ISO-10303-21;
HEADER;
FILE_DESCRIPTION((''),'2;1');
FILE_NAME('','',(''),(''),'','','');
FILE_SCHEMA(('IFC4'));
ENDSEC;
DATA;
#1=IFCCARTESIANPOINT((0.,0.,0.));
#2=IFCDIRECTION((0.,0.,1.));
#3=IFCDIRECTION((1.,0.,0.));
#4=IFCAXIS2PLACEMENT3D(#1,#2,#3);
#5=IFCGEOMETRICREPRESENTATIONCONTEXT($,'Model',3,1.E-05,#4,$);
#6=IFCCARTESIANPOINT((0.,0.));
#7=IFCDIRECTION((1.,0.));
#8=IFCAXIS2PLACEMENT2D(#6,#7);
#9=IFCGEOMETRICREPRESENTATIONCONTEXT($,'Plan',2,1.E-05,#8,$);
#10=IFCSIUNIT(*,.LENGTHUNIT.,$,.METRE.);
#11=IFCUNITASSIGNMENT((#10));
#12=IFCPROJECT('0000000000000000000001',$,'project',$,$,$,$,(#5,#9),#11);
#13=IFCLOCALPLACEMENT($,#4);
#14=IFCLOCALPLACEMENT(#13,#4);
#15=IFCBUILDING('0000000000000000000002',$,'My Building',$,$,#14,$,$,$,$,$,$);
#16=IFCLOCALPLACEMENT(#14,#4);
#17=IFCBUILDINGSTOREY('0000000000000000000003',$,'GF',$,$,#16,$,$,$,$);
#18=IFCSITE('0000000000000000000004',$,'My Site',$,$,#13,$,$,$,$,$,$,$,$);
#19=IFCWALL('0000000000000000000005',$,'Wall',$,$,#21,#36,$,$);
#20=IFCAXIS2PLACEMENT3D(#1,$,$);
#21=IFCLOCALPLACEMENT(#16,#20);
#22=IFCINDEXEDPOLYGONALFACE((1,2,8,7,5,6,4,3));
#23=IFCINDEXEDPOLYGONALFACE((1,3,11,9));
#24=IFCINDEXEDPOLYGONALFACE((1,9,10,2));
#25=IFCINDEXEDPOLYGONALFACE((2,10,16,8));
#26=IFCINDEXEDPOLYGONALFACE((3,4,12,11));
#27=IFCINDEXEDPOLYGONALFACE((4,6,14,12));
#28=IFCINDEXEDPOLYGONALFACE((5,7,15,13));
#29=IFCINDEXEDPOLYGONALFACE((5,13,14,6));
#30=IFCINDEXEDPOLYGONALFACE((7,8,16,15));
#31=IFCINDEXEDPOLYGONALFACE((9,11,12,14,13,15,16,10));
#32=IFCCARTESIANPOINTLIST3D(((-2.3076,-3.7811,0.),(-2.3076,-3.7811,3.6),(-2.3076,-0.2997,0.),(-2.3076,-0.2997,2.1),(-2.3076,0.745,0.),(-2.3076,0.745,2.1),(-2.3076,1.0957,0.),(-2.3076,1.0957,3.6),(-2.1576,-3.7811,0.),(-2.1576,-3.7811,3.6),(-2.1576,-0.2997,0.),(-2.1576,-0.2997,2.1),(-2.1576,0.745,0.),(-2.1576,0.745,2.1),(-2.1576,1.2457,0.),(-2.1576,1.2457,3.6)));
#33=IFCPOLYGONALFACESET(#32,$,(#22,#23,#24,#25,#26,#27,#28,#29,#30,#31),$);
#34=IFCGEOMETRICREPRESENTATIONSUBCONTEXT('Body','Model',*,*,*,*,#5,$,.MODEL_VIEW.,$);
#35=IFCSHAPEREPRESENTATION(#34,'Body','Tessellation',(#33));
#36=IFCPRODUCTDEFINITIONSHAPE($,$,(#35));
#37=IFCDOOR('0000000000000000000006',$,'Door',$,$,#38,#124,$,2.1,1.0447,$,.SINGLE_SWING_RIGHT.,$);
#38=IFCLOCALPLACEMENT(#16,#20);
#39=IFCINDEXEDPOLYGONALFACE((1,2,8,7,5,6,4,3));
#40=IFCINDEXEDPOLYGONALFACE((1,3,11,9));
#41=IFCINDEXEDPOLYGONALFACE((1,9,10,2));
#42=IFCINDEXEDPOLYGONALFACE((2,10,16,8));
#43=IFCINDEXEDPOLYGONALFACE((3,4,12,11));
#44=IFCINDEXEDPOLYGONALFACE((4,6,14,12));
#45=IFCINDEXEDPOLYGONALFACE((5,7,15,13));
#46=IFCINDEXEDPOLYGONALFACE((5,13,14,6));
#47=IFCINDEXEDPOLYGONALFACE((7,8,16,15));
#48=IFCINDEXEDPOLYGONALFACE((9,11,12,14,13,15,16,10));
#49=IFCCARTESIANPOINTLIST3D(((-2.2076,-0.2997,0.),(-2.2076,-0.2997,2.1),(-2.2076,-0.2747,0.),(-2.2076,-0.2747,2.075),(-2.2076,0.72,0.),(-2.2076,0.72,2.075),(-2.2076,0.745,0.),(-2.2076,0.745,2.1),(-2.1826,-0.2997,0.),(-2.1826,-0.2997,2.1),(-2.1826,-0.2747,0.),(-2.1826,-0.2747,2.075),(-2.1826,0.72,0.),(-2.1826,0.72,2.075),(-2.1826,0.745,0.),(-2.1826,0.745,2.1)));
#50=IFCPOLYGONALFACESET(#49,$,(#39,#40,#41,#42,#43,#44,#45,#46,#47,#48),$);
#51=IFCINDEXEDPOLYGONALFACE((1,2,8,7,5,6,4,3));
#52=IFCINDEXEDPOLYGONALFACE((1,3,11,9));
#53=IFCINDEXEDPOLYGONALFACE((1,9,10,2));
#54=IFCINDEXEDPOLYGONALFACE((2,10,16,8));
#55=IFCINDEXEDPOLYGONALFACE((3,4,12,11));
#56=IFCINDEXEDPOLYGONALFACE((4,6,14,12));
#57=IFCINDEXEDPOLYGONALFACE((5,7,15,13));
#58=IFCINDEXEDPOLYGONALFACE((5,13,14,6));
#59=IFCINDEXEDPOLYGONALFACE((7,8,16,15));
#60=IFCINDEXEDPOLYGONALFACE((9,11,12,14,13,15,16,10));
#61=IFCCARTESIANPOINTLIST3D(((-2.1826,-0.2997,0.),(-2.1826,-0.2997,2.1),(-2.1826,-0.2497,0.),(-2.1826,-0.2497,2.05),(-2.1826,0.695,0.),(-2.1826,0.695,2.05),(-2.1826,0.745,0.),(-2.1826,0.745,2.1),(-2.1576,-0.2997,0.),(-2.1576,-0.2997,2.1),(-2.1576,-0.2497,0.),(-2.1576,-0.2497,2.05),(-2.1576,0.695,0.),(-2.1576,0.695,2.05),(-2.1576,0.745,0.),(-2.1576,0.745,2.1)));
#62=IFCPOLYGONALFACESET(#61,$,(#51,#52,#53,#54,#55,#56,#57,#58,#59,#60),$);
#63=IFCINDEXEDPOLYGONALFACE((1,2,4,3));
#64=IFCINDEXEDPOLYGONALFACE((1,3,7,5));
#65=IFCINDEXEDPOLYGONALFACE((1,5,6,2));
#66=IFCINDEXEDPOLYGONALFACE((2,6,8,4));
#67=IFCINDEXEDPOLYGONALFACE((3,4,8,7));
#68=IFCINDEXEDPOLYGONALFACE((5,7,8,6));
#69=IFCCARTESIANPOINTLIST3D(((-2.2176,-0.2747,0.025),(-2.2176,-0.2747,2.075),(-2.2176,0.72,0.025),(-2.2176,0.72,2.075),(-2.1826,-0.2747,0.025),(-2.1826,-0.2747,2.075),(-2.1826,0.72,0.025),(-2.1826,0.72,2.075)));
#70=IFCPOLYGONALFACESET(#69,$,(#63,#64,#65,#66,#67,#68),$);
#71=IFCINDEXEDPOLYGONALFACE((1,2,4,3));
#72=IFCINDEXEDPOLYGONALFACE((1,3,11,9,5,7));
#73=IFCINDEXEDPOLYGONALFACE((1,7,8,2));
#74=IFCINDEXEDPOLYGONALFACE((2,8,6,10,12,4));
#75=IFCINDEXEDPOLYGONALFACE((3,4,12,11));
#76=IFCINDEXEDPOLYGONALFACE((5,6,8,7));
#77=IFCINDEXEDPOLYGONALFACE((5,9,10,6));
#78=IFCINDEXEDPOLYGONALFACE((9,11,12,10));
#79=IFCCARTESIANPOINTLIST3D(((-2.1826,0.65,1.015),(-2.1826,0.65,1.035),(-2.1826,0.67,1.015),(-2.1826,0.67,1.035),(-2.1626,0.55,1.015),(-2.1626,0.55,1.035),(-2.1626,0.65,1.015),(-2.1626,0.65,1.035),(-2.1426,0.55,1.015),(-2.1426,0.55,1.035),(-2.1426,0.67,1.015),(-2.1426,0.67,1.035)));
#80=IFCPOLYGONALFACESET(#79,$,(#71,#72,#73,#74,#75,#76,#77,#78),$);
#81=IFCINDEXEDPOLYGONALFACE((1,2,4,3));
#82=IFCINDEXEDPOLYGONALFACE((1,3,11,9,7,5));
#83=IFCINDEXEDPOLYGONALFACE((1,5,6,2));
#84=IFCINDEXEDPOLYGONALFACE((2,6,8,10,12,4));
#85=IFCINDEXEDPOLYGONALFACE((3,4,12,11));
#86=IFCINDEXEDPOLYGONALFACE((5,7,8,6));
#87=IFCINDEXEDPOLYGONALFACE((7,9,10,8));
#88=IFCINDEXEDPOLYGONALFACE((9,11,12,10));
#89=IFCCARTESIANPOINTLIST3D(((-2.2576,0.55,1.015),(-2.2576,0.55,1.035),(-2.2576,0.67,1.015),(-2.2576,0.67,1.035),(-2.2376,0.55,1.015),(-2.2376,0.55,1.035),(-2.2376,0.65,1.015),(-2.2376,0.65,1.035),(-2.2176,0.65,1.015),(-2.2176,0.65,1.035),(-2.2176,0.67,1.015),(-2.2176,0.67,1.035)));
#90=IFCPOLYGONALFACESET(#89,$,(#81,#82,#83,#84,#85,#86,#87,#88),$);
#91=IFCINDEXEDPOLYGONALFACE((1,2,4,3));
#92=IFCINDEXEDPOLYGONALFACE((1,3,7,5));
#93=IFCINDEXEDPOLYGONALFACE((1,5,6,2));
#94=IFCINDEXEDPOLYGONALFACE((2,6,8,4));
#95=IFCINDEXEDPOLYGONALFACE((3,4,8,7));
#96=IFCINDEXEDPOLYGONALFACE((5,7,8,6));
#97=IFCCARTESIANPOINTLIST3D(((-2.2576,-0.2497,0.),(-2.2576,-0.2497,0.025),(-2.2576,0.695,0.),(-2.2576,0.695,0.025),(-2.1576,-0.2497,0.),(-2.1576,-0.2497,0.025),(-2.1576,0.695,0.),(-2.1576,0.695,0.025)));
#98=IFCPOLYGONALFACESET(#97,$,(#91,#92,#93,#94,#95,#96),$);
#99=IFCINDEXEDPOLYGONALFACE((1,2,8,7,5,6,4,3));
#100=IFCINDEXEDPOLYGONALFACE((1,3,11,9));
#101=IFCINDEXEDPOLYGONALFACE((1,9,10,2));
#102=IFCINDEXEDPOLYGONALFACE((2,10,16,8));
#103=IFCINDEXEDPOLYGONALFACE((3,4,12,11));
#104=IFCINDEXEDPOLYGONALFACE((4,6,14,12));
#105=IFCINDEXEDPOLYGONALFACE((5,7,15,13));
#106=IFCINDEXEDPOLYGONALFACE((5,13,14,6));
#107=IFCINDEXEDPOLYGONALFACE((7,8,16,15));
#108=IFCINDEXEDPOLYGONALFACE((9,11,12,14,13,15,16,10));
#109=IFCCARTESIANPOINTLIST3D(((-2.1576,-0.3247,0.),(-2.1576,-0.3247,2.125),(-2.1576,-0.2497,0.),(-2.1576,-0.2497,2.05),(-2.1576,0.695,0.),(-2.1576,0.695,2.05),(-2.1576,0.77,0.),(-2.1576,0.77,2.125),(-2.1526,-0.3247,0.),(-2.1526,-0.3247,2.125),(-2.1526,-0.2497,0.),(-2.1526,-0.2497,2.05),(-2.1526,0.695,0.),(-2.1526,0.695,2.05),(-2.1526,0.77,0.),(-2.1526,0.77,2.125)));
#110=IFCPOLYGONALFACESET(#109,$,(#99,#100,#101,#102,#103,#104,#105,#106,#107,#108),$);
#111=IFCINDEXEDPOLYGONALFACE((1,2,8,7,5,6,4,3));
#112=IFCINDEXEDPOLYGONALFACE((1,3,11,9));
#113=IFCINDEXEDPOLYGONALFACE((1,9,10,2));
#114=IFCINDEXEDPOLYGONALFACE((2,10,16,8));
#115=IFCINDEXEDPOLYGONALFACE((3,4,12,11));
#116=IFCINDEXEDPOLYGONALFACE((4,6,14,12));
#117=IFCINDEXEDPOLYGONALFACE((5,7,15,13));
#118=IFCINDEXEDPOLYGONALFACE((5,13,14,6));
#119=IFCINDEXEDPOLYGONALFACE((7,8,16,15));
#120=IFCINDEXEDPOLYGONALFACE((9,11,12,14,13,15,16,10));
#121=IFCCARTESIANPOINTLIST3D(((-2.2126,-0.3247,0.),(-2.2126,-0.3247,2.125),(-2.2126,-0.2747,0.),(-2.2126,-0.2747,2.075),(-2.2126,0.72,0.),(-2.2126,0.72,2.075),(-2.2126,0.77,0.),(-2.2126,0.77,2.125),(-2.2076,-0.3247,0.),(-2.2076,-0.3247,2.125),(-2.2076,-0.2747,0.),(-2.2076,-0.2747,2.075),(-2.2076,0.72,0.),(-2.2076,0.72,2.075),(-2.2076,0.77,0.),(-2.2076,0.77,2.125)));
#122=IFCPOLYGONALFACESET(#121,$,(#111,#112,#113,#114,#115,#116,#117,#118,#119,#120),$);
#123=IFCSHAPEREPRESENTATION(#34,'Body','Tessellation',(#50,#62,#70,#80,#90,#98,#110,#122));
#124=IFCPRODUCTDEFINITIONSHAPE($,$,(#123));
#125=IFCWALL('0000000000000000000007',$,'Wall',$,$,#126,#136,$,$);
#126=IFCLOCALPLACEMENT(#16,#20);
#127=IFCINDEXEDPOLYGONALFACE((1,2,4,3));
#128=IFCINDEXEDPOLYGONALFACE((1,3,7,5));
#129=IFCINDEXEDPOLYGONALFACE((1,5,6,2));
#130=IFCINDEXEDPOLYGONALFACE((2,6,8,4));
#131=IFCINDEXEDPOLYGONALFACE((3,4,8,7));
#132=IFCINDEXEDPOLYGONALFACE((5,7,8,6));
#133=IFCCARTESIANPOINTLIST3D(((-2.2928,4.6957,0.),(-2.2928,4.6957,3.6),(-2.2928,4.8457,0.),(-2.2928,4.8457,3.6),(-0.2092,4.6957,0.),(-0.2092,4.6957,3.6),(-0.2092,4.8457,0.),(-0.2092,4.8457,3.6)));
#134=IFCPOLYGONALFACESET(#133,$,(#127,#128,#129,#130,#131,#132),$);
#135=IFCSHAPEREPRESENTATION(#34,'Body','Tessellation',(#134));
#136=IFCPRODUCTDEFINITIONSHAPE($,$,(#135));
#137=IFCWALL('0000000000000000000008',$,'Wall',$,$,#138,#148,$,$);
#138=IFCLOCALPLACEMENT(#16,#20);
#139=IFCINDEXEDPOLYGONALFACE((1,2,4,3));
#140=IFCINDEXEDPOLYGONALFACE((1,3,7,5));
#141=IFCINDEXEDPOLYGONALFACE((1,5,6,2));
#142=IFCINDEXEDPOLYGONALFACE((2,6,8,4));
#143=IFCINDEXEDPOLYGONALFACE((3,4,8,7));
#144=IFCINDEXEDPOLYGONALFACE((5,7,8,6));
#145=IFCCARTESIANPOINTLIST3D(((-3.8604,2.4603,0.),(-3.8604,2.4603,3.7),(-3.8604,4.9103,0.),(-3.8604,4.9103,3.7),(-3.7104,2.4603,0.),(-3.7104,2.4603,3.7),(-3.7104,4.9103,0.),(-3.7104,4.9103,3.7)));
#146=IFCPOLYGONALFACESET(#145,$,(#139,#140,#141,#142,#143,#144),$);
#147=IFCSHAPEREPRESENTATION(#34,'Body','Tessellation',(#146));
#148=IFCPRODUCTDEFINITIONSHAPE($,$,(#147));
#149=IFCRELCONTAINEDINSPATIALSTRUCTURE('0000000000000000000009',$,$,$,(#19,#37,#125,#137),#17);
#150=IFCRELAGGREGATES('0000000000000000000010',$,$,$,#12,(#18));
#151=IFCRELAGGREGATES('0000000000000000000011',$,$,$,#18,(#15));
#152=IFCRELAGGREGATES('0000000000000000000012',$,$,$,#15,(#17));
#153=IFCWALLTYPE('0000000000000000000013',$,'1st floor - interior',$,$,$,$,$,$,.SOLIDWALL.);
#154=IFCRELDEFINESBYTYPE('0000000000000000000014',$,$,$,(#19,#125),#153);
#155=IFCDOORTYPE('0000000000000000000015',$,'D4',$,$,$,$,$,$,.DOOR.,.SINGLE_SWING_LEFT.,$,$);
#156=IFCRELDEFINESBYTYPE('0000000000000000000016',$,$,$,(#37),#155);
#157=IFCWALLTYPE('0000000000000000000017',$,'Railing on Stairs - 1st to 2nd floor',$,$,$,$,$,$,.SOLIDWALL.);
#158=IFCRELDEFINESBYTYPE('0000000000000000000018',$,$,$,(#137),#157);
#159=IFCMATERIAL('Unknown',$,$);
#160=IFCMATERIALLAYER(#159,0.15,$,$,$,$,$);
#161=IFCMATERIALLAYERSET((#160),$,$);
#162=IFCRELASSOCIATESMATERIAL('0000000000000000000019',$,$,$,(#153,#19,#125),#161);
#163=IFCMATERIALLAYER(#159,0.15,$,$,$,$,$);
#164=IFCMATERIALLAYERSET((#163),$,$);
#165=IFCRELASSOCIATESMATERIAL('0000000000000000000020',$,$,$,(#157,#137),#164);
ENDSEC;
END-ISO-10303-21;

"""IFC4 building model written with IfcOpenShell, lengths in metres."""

from ifc_helpers import new_model, entity, si_unit, frame, origin_with_axes, origin_2d_with_axis, place, context, subcontext, project, spatial, line, indexed_curve, outline, extrude, shape, source, transform, mapped, material, layer, layer_set, layer_usage, type_object, type_shapes, element, fill, save


model = new_model("IFC4")

# Units and contexts
model_context = context("Model", 3, precision=1e-05, world=origin_with_axes())
plan_context = context("Plan", 2, precision=1e-05, world=origin_2d_with_axis())
body_context_1 = subcontext(model_context, "Body", "Model", "MODEL_VIEW")
body_context_2 = subcontext(plan_context, "Body", "Plan", "PLAN_VIEW")
ifc_project = project(units=[si_unit("LENGTHUNIT", "METRE")], contexts=[model_context, plan_context])

# Site, building, storey
site_placement = place(None, origin_with_axes())
site = spatial("IfcSite", under=ifc_project, at=site_placement, Name="My Site")
building_placement = place(site_placement, origin_with_axes())
building = spatial("IfcBuilding", under=site, at=building_placement, Name="My Building")
storey_placement = place(building_placement, origin_with_axes())
storey = spatial("IfcBuildingStorey", under=building, at=storey_placement, Name="GF")

# Shared definitions
ifc_material = material(Name="Unknown")

# Shared definitions
ifc_layer_1 = layer(ifc_material, 0.15)
ifc_layer_set_1 = layer_set([ifc_layer_1])
wall_type_1 = type_object("IfcWallType", Name="1st floor - interior", PredefinedType="SOLIDWALL", material=ifc_layer_set_1)

# Wall, opening, door
ifc_layer_usage_1 = layer_usage(ifc_layer_set_1, "AXIS2", "POSITIVE", 0.0)
wall_1_placement = place(storey_placement, frame((-2.3076, 1.0957, 0.0), z_axis=(0.0, 0.0, 1.0), x_axis=(0.0, -1.0, 0.0)))
wall_1 = element("IfcWall", 1, at=wall_1_placement, inside=storey, type_object=wall_type_1, material=ifc_layer_usage_1, Name="Wall", context=body_context_1, shape_type="SweptSolid", body=[
    extrude(outline(indexed_curve([(0.0, 0.0), (-0.15, 0.15), (4.8768, 0.15), (4.8768, 0.0)], segments=[line(1, 2, 3, 4, 1)])), origin_with_axes(), (0.0, 0.0, 1.0), 3.6),
])
shared_shape_1 = source(origin_with_axes(), body_context_1, "Body", "SweptSolid", [
    extrude(outline(indexed_curve([(0.0, 0.0), (1.0447, 0.0), (1.0447, 2.1), (0.0, 2.1)], segments=[line(1, 2, 3, 4, 1)])), frame((0.0, -0.6, 0.0), z_axis=(0.0, -1.0, 0.0), x_axis=(1.0, 0.0, 0.0)), (0.0, 0.0, -1.0), 1.2),
])
opening_1_placement = place(wall_1_placement, frame((1.3954, 0.15, 0.0), z_axis=(0.0, 0.0, 1.0), x_axis=(-1.0, 0.0, 0.0)))
opening_1 = element("IfcOpeningElement", 2, at=opening_1_placement, cuts=wall_1, PredefinedType="OPENING", context=body_context_1, shape_type="MappedRepresentation", body=[
    mapped(shared_shape_1, transform((0.0, 0.0, 0.0), x_axis=(1.0, 0.0, 0.0), y_axis=(0.0, 1.0, 0.0), z_axis=(0.0, 0.0, 1.0), scale=1.0)),
])
door_type_1 = type_object("IfcDoorType", Name="D4", OperationType="SINGLE_SWING_LEFT", PredefinedType="DOOR")
shared_shape_2 = source(origin_with_axes(), body_context_1, "Body", "SweptSolid", [
    extrude(outline(indexed_curve([(0.0, 0.0), (0.0, 2.1), (1.0447, 2.1), (1.0447, 0.0), (1.0197, 0.0), (1.0197, 2.075), (0.025, 2.075), (0.025, 0.0)], segments=[line(1, 2, 3, 4, 5, 6, 7, 8, 1)])), frame((0.0, 0.025, 0.0), z_axis=(0.0, -1.0, 0.0), x_axis=(1.0, 0.0, 0.0)), (0.0, 0.0, -1.0), 0.025),
    extrude(outline(indexed_curve([(0.0, 0.0), (0.0, 2.1), (1.0447, 2.1), (1.0447, 0.0), (0.9947, 0.0), (0.9947, 2.05), (0.05, 2.05), (0.05, 0.0)], segments=[line(1, 2, 3, 4, 5, 6, 7, 8, 1)])), frame((0.0, 0.0, 0.0), z_axis=(0.0, -1.0, 0.0), x_axis=(1.0, 0.0, 0.0)), (0.0, 0.0, -1.0), 0.025),
    extrude(outline(indexed_curve([(0.0, 0.0), (0.9947, 0.0), (0.9947, 0.035), (0.0, 0.035)], segments=[line(1, 2, 3, 4, 1)])), frame((0.025, 0.025, 0.025), z_axis=(0.0, 0.0, 1.0), x_axis=(1.0, 0.0, 0.0)), (0.0, 0.0, 1.0), 2.05),
    extrude(outline(indexed_curve([(0.0, 0.0), (0.0, -0.04), (-0.12, -0.04), (-0.12, -0.02), (-0.02, -0.02), (-0.02, 0.0)], segments=[line(1, 2, 3, 4, 5, 6, 1)])), frame((0.9697, 0.025, 1.015), z_axis=(0.0, 0.0, 1.0), x_axis=(1.0, 0.0, 0.0)), (0.0, 0.0, 1.0), 0.02),
    extrude(outline(indexed_curve([(0.0, 0.0), (0.0, 0.04), (-0.12, 0.04), (-0.12, 0.02), (-0.02, 0.02), (-0.02, 0.0)], segments=[line(1, 2, 3, 4, 5, 6, 1)])), frame((0.9697, 0.06, 1.015), z_axis=(0.0, 0.0, 1.0), x_axis=(1.0, 0.0, 0.0)), (0.0, 0.0, 1.0), 0.02),
    extrude(outline(indexed_curve([(0.0, 0.0), (0.9447, 0.0), (0.9447, 0.1), (0.0, 0.1)], segments=[line(1, 2, 3, 4, 1)])), frame((0.05, 0.0, 0.0), z_axis=(0.0, 0.0, 1.0), x_axis=(1.0, 0.0, 0.0)), (0.0, 0.0, 1.0), 0.025),
    extrude(outline(indexed_curve([(0.0, 0.0), (0.0, 2.125), (1.0947, 2.125), (1.0947, 0.0), (1.0197, 0.0), (1.0197, 2.05), (0.075, 2.05), (0.075, 0.0)], segments=[line(1, 2, 3, 4, 5, 6, 7, 8, 1)])), frame((-0.025, -0.005, 0.0), z_axis=(0.0, -1.0, 0.0), x_axis=(1.0, 0.0, 0.0)), (0.0, 0.0, -1.0), 0.005),
    extrude(outline(indexed_curve([(0.0, 0.0), (0.0, 2.125), (1.0947, 2.125), (1.0947, 0.0), (1.0447, 0.0), (1.0447, 2.075), (0.05, 2.075), (0.05, 0.0)], segments=[line(1, 2, 3, 4, 5, 6, 7, 8, 1)])), frame((-0.025, 0.05, 0.0), z_axis=(0.0, -1.0, 0.0), x_axis=(1.0, 0.0, 0.0)), (0.0, 0.0, -1.0), 0.005),
])
shared_shape_3 = source(origin_with_axes(), body_context_2, "Body", "Curve2D", [
    entity("IfcIndexedPolyCurve", entity("IfcCartesianPointList2D", [[0.0, 0.0], [0.0, 0.05], [0.025, 0.05], [0.025, 0.025], [0.05, 0.025], [0.05, 0.0]]), [entity("IfcLineIndex", [1, 2, 3, 4, 5, 6, 1])]),
    entity("IfcIndexedPolyCurve", entity("IfcCartesianPointList2D", [[1.0447, 0.0], [1.0447, 0.05], [1.0197, 0.05], [1.0197, 0.025], [0.9947, 0.025], [0.9947, 0.0]]), [entity("IfcLineIndex", [1, 2, 3, 4, 5, 6, 1])]),
    entity("IfcTrimmedCurve", entity("IfcEllipse", entity("IfcAxis2Placement2D", entity("IfcCartesianPoint", [0.06, 0.05]), entity("IfcDirection", [1.0, 0.0])), 0.9597, 0.9947), [entity("IfcCartesianPoint", [1.0197, 0.05])], [entity("IfcCartesianPoint", [0.06, 1.0447])], True, "CARTESIAN"),
    entity("IfcIndexedPolyCurve", entity("IfcCartesianPointList2D", [[0.025, 0.05], [0.06, 0.05], [0.06, 1.0447], [0.025, 1.0447]]), [entity("IfcLineIndex", [1, 2, 3, 4, 1])]),
])
type_shapes(door_type_1, [shared_shape_2, shared_shape_3])
door_1_placement = place(opening_1_placement, frame((0.0, 0.0, 0.0), z_axis=(0.0, 0.0, 1.0), x_axis=(1.0, 0.0, 0.0)))
door_1 = element("IfcDoor", 3, at=door_1_placement, inside=storey, type_object=door_type_1, Name="Door", OperationType="SINGLE_SWING_RIGHT", OverallHeight=2.1, OverallWidth=1.0447, shapes=[
    shape(body_context_1, "Body", "MappedRepresentation", [mapped(shared_shape_2, transform((0.0, 0.0, 0.0), x_axis=(1.0, 0.0, 0.0), y_axis=(0.0, 1.0, 0.0), z_axis=(0.0, 0.0, 1.0), scale=1.0))]),
    shape(body_context_2, "Body", "MappedRepresentation", [mapped(shared_shape_3, transform((0.0, 0.0, 0.0), x_axis=(1.0, 0.0, 0.0), y_axis=(0.0, 1.0, 0.0), z_axis=(0.0, 0.0, 1.0), scale=1.0))]),
])
fill(opening_1, door_1)

# Walls
ifc_layer_usage_2 = layer_usage(ifc_layer_set_1, "AXIS2", "POSITIVE", 0.0)
wall_2_placement = place(storey_placement, frame((-2.2928, 4.6957, 0.0), z_axis=(0.0, 0.0, 1.0), x_axis=(1.0, 0.0, 0.0)))
element("IfcWall", 4, at=wall_2_placement, inside=storey, type_object=wall_type_1, material=ifc_layer_usage_2, Name="Wall", context=body_context_1, shape_type="SweptSolid", body=[
    extrude(outline(indexed_curve([(0.0, 0.0), (0.0, 0.15), (2.0836, 0.15), (2.0836, 0.0)], segments=[line(1, 2, 3, 4, 1)])), origin_with_axes(), (0.0, 0.0, 1.0), 3.6),
])
ifc_layer_2 = layer(ifc_material, 0.15)
ifc_layer_set_2 = layer_set([ifc_layer_2])
ifc_layer_usage_3 = layer_usage(ifc_layer_set_2, "AXIS2", "POSITIVE", 0.0)
wall_type_2 = type_object("IfcWallType", Name="Railing on Stairs - 1st to 2nd floor", PredefinedType="SOLIDWALL", material=ifc_layer_set_2)
wall_3_placement = place(storey_placement, frame((-3.8604, 4.9103, 0.0), z_axis=(0.0, 0.0, 1.0), x_axis=(0.0, -1.0, 0.0)))
element("IfcWall", 5, at=wall_3_placement, inside=storey, type_object=wall_type_2, material=ifc_layer_usage_3, Name="Wall", context=body_context_1, shape_type="SweptSolid", body=[
    extrude(outline(indexed_curve([(0.0, 0.0), (0.0, 0.15), (2.45, 0.15), (2.45, 0.0)], segments=[line(1, 2, 3, 4, 1)])), origin_with_axes(), (0.0, 0.0, 1.0), 3.7),
])

save(model, "model.ifc")
